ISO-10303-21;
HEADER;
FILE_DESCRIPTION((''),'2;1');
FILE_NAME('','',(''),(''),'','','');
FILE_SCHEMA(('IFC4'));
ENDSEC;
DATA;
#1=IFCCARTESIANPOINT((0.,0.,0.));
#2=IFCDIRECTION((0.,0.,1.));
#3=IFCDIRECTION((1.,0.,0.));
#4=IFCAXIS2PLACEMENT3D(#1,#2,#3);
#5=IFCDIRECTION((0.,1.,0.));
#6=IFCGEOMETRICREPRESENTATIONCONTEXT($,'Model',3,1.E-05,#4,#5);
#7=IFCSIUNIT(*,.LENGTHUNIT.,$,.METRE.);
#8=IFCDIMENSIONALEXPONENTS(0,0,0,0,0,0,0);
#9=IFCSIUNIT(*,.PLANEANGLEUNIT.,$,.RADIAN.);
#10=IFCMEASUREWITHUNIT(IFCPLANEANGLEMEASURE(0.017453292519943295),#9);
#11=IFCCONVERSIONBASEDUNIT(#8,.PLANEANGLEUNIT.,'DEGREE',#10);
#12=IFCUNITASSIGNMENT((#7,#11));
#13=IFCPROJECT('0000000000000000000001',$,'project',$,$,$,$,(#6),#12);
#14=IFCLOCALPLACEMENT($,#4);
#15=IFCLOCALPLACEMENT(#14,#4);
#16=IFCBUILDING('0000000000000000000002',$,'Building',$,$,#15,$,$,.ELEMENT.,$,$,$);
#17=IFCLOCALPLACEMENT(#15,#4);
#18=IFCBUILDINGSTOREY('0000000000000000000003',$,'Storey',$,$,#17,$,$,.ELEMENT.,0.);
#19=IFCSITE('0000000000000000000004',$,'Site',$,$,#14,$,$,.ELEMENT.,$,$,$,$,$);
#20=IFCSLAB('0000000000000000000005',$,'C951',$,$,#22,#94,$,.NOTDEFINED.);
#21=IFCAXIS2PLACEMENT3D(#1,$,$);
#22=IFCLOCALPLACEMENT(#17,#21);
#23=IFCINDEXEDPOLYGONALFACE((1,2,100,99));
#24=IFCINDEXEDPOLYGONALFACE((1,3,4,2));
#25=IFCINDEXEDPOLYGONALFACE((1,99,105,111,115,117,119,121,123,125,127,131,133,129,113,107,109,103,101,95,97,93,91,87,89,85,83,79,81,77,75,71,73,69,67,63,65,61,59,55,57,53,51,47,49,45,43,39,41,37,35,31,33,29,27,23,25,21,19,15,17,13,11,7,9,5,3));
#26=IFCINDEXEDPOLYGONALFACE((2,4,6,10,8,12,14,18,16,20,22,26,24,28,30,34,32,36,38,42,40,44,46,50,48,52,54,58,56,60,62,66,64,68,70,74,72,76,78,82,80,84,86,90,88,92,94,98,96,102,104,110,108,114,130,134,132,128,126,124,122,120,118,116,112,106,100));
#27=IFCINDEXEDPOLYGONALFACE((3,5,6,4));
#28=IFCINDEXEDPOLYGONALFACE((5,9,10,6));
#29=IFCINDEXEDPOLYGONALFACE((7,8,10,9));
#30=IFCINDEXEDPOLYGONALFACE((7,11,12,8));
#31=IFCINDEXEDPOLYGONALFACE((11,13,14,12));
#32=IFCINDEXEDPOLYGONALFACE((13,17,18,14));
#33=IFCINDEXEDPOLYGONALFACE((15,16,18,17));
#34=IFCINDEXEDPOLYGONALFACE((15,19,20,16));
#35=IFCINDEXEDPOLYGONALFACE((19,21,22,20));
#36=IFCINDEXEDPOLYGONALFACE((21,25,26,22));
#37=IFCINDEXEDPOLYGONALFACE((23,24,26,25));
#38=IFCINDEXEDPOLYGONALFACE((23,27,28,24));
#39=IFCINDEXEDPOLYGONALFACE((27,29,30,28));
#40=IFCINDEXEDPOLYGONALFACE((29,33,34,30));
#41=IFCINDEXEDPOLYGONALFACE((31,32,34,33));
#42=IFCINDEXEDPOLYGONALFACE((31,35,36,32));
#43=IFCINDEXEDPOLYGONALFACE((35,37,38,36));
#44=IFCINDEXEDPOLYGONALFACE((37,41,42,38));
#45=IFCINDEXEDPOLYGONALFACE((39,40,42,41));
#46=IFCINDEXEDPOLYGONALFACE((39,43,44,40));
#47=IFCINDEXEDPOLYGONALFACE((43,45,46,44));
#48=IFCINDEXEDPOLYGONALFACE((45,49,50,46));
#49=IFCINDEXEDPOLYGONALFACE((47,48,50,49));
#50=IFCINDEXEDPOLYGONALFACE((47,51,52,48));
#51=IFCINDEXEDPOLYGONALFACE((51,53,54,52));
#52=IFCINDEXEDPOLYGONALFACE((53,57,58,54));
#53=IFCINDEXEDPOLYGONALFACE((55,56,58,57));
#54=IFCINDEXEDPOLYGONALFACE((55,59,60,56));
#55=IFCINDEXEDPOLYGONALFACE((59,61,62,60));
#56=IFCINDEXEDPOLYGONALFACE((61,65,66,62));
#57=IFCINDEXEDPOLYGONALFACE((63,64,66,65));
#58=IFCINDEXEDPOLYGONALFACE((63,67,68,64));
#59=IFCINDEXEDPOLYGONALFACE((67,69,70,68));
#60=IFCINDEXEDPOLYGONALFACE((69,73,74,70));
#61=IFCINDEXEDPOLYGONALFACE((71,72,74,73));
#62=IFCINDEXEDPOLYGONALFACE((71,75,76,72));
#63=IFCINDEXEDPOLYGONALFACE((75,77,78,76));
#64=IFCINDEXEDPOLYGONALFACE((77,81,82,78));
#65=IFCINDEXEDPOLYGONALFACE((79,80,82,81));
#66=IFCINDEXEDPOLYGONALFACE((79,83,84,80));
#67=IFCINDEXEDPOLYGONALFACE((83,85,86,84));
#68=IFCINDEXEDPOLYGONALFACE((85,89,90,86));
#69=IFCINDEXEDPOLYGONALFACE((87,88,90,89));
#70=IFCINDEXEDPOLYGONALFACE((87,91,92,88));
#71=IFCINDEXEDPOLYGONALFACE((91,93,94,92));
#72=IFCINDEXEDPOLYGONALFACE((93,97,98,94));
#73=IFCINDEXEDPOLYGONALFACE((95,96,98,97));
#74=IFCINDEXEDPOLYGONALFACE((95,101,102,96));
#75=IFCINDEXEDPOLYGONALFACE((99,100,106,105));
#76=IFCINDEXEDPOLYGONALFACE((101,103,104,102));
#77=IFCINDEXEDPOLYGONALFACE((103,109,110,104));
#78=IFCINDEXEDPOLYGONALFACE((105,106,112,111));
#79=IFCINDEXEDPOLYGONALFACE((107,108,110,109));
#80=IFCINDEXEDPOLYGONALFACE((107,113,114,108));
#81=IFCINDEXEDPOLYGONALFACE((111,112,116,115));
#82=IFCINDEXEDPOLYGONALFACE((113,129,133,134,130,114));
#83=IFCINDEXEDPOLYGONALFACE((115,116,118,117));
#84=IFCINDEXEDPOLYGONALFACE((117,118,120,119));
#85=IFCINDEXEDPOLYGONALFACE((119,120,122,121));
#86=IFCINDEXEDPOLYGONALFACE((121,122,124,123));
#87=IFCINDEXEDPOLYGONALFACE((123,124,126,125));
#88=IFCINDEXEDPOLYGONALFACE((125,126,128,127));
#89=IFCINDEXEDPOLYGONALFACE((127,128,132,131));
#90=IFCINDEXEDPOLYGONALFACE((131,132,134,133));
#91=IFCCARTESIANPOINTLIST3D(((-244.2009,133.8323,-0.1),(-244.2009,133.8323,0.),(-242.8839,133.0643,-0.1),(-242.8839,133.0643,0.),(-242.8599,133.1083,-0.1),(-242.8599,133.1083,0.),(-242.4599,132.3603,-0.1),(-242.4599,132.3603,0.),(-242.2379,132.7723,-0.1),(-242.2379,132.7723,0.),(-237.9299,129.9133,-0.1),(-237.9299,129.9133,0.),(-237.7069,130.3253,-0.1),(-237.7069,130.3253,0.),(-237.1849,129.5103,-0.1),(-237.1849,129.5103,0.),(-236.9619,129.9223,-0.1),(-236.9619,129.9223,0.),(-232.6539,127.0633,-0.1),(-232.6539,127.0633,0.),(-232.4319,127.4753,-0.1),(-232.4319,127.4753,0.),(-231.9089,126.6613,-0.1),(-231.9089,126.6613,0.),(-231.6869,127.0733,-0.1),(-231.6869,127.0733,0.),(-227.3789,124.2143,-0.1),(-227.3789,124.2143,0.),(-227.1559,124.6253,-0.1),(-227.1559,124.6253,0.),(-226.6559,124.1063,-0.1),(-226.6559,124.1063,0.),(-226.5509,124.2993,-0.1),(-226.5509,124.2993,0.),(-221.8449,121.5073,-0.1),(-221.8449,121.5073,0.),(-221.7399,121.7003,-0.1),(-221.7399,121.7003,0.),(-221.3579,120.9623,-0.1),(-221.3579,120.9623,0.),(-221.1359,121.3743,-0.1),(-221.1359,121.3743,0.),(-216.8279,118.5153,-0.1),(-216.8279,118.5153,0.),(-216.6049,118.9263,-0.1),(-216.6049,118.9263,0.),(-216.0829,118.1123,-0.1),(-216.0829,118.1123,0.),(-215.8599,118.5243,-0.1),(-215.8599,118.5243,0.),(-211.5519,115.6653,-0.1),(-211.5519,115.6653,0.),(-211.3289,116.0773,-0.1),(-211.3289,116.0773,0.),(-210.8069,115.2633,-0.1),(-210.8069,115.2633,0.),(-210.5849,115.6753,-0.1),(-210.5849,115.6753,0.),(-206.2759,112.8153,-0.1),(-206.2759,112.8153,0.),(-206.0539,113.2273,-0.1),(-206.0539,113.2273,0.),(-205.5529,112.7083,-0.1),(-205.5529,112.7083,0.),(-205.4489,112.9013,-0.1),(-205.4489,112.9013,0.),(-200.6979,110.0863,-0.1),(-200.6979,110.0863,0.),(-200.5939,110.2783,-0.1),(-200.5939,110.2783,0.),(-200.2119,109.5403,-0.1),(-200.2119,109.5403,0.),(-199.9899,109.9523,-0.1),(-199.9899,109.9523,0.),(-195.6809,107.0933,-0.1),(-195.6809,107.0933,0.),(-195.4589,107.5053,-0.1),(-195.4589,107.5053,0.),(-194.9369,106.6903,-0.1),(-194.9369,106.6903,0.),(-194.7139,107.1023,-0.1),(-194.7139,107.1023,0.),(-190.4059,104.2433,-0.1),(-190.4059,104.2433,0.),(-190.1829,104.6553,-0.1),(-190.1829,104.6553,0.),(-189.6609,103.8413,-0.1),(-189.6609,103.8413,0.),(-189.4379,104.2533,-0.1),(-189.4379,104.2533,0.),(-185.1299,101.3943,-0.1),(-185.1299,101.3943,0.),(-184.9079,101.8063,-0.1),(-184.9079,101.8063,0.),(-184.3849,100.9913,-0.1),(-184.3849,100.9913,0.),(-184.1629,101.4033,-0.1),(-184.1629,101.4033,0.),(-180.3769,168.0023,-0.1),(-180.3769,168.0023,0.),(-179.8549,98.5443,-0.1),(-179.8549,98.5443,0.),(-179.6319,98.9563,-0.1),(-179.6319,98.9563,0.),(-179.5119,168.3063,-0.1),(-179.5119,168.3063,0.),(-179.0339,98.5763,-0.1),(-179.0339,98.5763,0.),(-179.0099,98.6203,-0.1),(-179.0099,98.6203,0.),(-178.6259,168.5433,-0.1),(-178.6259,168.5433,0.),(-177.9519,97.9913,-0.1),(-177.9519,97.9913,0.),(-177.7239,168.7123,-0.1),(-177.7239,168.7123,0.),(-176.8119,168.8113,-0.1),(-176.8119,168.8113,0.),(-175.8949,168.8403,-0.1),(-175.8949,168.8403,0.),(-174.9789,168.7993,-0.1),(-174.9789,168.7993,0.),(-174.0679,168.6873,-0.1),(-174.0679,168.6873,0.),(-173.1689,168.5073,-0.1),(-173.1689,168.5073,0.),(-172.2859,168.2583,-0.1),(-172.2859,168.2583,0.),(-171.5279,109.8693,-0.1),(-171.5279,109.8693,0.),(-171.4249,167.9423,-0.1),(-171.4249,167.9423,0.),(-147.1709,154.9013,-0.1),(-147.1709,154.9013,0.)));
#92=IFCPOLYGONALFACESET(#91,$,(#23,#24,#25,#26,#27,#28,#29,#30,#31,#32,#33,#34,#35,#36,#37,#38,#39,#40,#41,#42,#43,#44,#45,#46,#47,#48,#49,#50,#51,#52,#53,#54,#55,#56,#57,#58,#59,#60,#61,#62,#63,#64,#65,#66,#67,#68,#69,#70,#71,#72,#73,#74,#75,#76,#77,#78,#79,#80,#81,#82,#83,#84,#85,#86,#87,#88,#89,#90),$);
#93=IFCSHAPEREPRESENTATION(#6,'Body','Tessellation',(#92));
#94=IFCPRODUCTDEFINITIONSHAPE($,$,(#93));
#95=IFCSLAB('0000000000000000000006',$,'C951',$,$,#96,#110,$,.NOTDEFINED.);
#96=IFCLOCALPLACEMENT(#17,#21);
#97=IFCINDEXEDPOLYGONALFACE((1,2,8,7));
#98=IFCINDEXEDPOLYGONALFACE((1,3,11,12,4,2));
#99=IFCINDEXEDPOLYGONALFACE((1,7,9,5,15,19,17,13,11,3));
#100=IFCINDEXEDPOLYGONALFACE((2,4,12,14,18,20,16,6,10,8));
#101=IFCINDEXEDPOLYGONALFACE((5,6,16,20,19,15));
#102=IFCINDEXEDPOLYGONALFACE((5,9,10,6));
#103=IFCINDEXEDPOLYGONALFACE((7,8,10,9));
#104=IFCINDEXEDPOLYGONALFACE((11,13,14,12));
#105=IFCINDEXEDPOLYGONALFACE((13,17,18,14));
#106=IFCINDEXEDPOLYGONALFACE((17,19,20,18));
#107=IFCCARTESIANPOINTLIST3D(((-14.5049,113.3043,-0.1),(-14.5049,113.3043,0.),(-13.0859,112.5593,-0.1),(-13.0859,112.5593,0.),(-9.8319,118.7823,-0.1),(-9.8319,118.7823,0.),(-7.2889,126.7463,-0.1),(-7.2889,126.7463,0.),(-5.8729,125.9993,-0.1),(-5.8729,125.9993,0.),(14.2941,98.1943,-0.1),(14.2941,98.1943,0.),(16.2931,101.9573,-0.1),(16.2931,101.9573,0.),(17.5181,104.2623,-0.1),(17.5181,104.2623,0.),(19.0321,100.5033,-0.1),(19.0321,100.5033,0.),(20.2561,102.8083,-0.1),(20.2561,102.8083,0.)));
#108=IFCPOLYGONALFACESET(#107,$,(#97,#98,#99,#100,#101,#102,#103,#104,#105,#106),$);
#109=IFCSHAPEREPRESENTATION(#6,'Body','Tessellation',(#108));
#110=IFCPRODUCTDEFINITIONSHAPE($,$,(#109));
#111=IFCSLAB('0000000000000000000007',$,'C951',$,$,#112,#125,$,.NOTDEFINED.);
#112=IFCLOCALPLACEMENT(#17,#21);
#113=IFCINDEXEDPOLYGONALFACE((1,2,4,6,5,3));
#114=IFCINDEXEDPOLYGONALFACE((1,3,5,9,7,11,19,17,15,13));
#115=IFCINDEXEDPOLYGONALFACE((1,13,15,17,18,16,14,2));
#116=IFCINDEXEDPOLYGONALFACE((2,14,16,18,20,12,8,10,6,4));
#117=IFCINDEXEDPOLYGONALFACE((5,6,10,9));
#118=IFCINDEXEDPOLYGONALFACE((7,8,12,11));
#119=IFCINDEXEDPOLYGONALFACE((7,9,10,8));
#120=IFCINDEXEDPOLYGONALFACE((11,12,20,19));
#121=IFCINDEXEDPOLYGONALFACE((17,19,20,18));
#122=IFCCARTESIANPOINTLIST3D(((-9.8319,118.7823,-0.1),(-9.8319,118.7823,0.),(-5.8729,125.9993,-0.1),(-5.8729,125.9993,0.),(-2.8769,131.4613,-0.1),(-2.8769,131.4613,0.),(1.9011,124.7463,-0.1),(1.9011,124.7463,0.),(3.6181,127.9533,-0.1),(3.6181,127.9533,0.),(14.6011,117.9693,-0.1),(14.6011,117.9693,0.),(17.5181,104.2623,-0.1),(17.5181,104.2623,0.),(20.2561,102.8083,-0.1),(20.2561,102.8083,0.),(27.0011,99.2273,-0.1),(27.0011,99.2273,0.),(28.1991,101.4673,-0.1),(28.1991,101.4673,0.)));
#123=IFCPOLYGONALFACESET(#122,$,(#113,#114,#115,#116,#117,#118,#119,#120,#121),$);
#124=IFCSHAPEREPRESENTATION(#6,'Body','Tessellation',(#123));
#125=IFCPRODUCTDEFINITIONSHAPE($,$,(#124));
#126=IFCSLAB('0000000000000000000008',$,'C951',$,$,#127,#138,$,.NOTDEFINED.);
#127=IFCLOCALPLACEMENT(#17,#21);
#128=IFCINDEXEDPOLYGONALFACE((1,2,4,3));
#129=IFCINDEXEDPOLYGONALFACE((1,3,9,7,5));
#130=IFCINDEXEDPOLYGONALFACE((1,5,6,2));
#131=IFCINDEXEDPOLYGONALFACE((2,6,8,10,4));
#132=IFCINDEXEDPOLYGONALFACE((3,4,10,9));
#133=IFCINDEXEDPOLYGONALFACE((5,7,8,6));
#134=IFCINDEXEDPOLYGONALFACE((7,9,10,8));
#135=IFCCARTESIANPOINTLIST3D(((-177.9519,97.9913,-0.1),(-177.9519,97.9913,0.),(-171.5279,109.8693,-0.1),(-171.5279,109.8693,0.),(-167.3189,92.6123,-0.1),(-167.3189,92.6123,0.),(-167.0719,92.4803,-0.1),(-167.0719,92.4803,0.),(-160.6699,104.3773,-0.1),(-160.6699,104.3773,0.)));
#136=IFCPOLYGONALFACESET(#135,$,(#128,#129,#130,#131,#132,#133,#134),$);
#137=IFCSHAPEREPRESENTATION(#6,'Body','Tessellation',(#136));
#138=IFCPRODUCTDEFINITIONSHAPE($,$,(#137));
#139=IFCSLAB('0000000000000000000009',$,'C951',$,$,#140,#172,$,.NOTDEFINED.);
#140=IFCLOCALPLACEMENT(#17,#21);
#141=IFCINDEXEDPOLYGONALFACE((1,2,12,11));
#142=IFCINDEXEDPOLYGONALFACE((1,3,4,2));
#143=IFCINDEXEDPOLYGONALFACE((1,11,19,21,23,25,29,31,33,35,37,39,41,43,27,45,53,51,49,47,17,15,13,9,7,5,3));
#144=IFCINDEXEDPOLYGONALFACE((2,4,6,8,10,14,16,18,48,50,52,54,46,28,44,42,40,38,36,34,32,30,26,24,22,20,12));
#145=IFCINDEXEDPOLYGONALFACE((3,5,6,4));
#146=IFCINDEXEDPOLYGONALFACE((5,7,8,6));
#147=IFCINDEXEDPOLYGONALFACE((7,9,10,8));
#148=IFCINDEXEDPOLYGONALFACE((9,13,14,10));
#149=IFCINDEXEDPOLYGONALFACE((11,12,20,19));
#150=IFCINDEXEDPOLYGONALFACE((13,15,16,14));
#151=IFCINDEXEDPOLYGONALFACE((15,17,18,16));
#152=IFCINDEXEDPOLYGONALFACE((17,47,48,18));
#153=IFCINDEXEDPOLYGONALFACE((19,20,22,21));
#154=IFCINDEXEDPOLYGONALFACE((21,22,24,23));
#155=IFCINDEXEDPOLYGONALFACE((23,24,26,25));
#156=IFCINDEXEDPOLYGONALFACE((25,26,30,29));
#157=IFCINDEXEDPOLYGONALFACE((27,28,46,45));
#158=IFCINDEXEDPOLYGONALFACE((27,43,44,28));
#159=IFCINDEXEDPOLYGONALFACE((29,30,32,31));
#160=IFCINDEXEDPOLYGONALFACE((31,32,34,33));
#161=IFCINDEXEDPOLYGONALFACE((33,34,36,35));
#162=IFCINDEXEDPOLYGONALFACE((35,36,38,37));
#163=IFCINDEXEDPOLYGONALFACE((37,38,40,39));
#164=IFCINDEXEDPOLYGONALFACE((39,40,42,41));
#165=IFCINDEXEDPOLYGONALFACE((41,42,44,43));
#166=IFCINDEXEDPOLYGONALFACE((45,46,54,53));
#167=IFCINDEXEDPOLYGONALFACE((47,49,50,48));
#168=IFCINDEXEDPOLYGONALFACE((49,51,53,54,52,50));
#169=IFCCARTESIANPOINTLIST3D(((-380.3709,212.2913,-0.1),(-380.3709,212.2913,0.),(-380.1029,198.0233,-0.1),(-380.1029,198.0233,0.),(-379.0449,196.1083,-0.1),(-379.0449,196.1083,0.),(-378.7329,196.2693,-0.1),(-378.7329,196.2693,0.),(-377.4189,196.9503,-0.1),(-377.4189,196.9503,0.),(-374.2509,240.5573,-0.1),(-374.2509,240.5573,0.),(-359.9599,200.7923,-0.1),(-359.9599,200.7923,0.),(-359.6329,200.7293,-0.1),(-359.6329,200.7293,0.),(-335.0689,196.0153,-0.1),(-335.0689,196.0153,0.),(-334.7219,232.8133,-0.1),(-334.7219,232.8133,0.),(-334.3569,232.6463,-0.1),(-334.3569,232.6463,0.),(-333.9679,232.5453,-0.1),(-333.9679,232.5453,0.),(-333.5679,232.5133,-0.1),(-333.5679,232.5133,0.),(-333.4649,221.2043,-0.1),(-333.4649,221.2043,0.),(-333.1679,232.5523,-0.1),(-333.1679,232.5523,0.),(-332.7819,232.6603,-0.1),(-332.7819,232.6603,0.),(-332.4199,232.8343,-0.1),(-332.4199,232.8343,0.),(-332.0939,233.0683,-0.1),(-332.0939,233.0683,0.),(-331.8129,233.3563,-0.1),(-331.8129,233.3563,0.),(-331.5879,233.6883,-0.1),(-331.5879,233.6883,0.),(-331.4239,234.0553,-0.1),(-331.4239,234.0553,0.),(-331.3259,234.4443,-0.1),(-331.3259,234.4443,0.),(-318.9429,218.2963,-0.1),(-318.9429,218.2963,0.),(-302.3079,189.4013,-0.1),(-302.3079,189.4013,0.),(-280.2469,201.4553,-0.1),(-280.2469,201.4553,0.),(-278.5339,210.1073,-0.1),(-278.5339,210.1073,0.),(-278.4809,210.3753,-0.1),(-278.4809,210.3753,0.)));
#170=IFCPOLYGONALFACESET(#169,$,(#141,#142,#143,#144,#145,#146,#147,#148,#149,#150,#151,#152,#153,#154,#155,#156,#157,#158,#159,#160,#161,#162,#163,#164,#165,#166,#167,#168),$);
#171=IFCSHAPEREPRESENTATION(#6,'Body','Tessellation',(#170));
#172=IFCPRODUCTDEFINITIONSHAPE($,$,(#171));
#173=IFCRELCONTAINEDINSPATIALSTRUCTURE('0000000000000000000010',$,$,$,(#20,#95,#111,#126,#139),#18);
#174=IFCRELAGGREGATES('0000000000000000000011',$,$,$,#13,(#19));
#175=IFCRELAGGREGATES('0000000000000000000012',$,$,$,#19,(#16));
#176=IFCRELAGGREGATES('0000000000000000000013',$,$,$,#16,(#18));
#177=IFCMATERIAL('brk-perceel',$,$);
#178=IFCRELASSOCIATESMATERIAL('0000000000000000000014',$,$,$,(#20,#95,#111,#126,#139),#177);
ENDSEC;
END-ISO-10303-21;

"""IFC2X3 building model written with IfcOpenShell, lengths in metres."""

from ifc_helpers import new_model, entity, si_unit, converted_unit, direction, frame, origin_with_axes, place, context, project, spatial, polyline, outline, extrude, material, element, save


model = new_model("IFC2X3")

# Units and contexts
model_context = context("Model", 3, precision=1e-05, world=origin_with_axes(), true_north=direction((0.0, 1.0, 0.0)))
ifc_project = project(units=[si_unit("LENGTHUNIT", "METRE"), converted_unit("PLANEANGLEUNIT", "DEGREE", entity("IfcPlaneAngleMeasure", 0.017453292519943295), si_unit("PLANEANGLEUNIT", "RADIAN"), dimensions=[0, 0, 0, 0, 0, 0, 0])], contexts=[model_context])

# Site, building, storey
site_placement = place(None, origin_with_axes())
site = spatial("IfcSite", under=ifc_project, at=site_placement, Name="Site", CompositionType="ELEMENT")
building_placement = place(site_placement, origin_with_axes())
building = spatial("IfcBuilding", under=site, at=building_placement, Name="Building", CompositionType="ELEMENT")
storey_placement = place(building_placement, origin_with_axes())
storey = spatial("IfcBuildingStorey", under=building, at=storey_placement, Name="Storey", CompositionType="ELEMENT", Elevation=0.0)

# Slabs
ifc_material = material(Name="brk-perceel")
slab_1_placement = place(storey_placement, frame((0.0, 0.0, -0.1), z_axis=(0.0, 0.0, 1.0), x_axis=(1.0, 0.0, 0.0)))
element("IfcSlab", 1, at=slab_1_placement, inside=storey, material=ifc_material, Name="C951", PredefinedType="NOTDEFINED", context=model_context, shape_type="SweptSolid", body=[
    extrude(outline(polyline([(-179.8549, 98.5443), (-184.3849, 100.9913), (-184.1629, 101.4033), (-184.9079, 101.8063), (-185.1299, 101.3943), (-189.6609, 103.8413), (-189.4379, 104.2533), (-190.1829, 104.6553), (-190.4059, 104.2433), (-194.9369, 106.6903), (-194.7139, 107.1023), (-195.4589, 107.5053), (-195.6809, 107.0933), (-200.2119, 109.5403), (-199.9899, 109.9523), (-200.5939, 110.2783), (-200.6979, 110.0863), (-205.5529, 112.7083), (-205.4489, 112.9013), (-206.0539, 113.2273), (-206.2759, 112.8153), (-210.8069, 115.2633), (-210.5849, 115.6753), (-211.3289, 116.0773), (-211.5519, 115.6653), (-216.0829, 118.1123), (-215.8599, 118.5243), (-216.6049, 118.9263), (-216.8279, 118.5153), (-221.3579, 120.9623), (-221.1359, 121.3743), (-221.7399, 121.7003), (-221.8449, 121.5073), (-226.6559, 124.1063), (-226.5509, 124.2993), (-227.1559, 124.6253), (-227.3789, 124.2143), (-231.9089, 126.6613), (-231.6869, 127.0733), (-232.4319, 127.4753), (-232.6539, 127.0633), (-237.1849, 129.5103), (-236.9619, 129.9223), (-237.7069, 130.3253), (-237.9299, 129.9133), (-242.4599, 132.3603), (-242.2379, 132.7723), (-242.8599, 133.1083), (-242.8839, 133.0643), (-244.2009, 133.8323), (-180.3769, 168.0023), (-179.5119, 168.3063), (-178.6259, 168.5433), (-177.7239, 168.7123), (-176.8119, 168.8113), (-175.8949, 168.8403), (-174.9789, 168.7993), (-174.0679, 168.6873), (-173.1689, 168.5073), (-172.2859, 168.2583), (-171.4249, 167.9423), (-147.1709, 154.9013), (-171.5279, 109.8693), (-177.9519, 97.9913), (-179.0339, 98.5763), (-179.0099, 98.6203), (-179.6319, 98.9563), (-179.8549, 98.5443)])), origin_with_axes(), (0.0, 0.0, 1.0), 0.1),
])
slab_2_placement = place(storey_placement, frame((0.0, 0.0, -0.1), z_axis=(0.0, 0.0, 1.0), x_axis=(1.0, 0.0, 0.0)))
element("IfcSlab", 2, at=slab_2_placement, inside=storey, material=ifc_material, Name="C951", PredefinedType="NOTDEFINED", context=model_context, shape_type="SweptSolid", body=[
    extrude(outline(polyline([(19.0321, 100.5033), (16.2931, 101.9573), (14.2941, 98.1943), (-13.0859, 112.5593), (-14.5049, 113.3043), (-7.2889, 126.7463), (-5.8729, 125.9993), (-9.8319, 118.7823), (17.5181, 104.2623), (20.2561, 102.8083), (19.0321, 100.5033)])), origin_with_axes(), (0.0, 0.0, 1.0), 0.1),
])
slab_3_placement = place(storey_placement, frame((0.0, 0.0, -0.1), z_axis=(0.0, 0.0, 1.0), x_axis=(1.0, 0.0, 0.0)))
element("IfcSlab", 3, at=slab_3_placement, inside=storey, material=ifc_material, Name="C951", PredefinedType="NOTDEFINED", context=model_context, shape_type="SweptSolid", body=[
    extrude(outline(polyline([(-2.8769, 131.4613), (3.6181, 127.9533), (1.9011, 124.7463), (14.6011, 117.9693), (28.1991, 101.4673), (27.0011, 99.2273), (20.2561, 102.8083), (17.5181, 104.2623), (-9.8319, 118.7823), (-5.8729, 125.9993), (-2.8769, 131.4613)])), origin_with_axes(), (0.0, 0.0, 1.0), 0.1),
])
slab_4_placement = place(storey_placement, frame((0.0, 0.0, -0.1), z_axis=(0.0, 0.0, 1.0), x_axis=(1.0, 0.0, 0.0)))
element("IfcSlab", 4, at=slab_4_placement, inside=storey, material=ifc_material, Name="C951", PredefinedType="NOTDEFINED", context=model_context, shape_type="SweptSolid", body=[
    extrude(outline(polyline([(-177.9519, 97.9913), (-171.5279, 109.8693), (-160.6699, 104.3773), (-167.0719, 92.4803), (-167.3189, 92.6123), (-177.9519, 97.9913)])), origin_with_axes(), (0.0, 0.0, 1.0), 0.1),
])
slab_5_placement = place(storey_placement, frame((0.0, 0.0, -0.1), z_axis=(0.0, 0.0, 1.0), x_axis=(1.0, 0.0, 0.0)))
element("IfcSlab", 5, at=slab_5_placement, inside=storey, material=ifc_material, Name="C951", PredefinedType="NOTDEFINED", context=model_context, shape_type="SweptSolid", body=[
    extrude(outline(polyline([(-333.4649, 221.2043), (-318.9429, 218.2963), (-278.4809, 210.3753), (-278.5339, 210.1073), (-280.2469, 201.4553), (-302.3079, 189.4013), (-335.0689, 196.0153), (-359.6329, 200.7293), (-359.9599, 200.7923), (-377.4189, 196.9503), (-378.7329, 196.2693), (-379.0449, 196.1083), (-380.1029, 198.0233), (-380.3709, 212.2913), (-374.2509, 240.5573), (-334.7219, 232.8133), (-334.3569, 232.6463), (-333.9679, 232.5453), (-333.5679, 232.5133), (-333.1679, 232.5523), (-332.7819, 232.6603), (-332.4199, 232.8343), (-332.0939, 233.0683), (-331.8129, 233.3563), (-331.5879, 233.6883), (-331.4239, 234.0553), (-331.3259, 234.4443), (-333.4649, 221.2043)])), origin_with_axes(), (0.0, 0.0, 1.0), 0.1),
])

save(model, "model.ifc")
